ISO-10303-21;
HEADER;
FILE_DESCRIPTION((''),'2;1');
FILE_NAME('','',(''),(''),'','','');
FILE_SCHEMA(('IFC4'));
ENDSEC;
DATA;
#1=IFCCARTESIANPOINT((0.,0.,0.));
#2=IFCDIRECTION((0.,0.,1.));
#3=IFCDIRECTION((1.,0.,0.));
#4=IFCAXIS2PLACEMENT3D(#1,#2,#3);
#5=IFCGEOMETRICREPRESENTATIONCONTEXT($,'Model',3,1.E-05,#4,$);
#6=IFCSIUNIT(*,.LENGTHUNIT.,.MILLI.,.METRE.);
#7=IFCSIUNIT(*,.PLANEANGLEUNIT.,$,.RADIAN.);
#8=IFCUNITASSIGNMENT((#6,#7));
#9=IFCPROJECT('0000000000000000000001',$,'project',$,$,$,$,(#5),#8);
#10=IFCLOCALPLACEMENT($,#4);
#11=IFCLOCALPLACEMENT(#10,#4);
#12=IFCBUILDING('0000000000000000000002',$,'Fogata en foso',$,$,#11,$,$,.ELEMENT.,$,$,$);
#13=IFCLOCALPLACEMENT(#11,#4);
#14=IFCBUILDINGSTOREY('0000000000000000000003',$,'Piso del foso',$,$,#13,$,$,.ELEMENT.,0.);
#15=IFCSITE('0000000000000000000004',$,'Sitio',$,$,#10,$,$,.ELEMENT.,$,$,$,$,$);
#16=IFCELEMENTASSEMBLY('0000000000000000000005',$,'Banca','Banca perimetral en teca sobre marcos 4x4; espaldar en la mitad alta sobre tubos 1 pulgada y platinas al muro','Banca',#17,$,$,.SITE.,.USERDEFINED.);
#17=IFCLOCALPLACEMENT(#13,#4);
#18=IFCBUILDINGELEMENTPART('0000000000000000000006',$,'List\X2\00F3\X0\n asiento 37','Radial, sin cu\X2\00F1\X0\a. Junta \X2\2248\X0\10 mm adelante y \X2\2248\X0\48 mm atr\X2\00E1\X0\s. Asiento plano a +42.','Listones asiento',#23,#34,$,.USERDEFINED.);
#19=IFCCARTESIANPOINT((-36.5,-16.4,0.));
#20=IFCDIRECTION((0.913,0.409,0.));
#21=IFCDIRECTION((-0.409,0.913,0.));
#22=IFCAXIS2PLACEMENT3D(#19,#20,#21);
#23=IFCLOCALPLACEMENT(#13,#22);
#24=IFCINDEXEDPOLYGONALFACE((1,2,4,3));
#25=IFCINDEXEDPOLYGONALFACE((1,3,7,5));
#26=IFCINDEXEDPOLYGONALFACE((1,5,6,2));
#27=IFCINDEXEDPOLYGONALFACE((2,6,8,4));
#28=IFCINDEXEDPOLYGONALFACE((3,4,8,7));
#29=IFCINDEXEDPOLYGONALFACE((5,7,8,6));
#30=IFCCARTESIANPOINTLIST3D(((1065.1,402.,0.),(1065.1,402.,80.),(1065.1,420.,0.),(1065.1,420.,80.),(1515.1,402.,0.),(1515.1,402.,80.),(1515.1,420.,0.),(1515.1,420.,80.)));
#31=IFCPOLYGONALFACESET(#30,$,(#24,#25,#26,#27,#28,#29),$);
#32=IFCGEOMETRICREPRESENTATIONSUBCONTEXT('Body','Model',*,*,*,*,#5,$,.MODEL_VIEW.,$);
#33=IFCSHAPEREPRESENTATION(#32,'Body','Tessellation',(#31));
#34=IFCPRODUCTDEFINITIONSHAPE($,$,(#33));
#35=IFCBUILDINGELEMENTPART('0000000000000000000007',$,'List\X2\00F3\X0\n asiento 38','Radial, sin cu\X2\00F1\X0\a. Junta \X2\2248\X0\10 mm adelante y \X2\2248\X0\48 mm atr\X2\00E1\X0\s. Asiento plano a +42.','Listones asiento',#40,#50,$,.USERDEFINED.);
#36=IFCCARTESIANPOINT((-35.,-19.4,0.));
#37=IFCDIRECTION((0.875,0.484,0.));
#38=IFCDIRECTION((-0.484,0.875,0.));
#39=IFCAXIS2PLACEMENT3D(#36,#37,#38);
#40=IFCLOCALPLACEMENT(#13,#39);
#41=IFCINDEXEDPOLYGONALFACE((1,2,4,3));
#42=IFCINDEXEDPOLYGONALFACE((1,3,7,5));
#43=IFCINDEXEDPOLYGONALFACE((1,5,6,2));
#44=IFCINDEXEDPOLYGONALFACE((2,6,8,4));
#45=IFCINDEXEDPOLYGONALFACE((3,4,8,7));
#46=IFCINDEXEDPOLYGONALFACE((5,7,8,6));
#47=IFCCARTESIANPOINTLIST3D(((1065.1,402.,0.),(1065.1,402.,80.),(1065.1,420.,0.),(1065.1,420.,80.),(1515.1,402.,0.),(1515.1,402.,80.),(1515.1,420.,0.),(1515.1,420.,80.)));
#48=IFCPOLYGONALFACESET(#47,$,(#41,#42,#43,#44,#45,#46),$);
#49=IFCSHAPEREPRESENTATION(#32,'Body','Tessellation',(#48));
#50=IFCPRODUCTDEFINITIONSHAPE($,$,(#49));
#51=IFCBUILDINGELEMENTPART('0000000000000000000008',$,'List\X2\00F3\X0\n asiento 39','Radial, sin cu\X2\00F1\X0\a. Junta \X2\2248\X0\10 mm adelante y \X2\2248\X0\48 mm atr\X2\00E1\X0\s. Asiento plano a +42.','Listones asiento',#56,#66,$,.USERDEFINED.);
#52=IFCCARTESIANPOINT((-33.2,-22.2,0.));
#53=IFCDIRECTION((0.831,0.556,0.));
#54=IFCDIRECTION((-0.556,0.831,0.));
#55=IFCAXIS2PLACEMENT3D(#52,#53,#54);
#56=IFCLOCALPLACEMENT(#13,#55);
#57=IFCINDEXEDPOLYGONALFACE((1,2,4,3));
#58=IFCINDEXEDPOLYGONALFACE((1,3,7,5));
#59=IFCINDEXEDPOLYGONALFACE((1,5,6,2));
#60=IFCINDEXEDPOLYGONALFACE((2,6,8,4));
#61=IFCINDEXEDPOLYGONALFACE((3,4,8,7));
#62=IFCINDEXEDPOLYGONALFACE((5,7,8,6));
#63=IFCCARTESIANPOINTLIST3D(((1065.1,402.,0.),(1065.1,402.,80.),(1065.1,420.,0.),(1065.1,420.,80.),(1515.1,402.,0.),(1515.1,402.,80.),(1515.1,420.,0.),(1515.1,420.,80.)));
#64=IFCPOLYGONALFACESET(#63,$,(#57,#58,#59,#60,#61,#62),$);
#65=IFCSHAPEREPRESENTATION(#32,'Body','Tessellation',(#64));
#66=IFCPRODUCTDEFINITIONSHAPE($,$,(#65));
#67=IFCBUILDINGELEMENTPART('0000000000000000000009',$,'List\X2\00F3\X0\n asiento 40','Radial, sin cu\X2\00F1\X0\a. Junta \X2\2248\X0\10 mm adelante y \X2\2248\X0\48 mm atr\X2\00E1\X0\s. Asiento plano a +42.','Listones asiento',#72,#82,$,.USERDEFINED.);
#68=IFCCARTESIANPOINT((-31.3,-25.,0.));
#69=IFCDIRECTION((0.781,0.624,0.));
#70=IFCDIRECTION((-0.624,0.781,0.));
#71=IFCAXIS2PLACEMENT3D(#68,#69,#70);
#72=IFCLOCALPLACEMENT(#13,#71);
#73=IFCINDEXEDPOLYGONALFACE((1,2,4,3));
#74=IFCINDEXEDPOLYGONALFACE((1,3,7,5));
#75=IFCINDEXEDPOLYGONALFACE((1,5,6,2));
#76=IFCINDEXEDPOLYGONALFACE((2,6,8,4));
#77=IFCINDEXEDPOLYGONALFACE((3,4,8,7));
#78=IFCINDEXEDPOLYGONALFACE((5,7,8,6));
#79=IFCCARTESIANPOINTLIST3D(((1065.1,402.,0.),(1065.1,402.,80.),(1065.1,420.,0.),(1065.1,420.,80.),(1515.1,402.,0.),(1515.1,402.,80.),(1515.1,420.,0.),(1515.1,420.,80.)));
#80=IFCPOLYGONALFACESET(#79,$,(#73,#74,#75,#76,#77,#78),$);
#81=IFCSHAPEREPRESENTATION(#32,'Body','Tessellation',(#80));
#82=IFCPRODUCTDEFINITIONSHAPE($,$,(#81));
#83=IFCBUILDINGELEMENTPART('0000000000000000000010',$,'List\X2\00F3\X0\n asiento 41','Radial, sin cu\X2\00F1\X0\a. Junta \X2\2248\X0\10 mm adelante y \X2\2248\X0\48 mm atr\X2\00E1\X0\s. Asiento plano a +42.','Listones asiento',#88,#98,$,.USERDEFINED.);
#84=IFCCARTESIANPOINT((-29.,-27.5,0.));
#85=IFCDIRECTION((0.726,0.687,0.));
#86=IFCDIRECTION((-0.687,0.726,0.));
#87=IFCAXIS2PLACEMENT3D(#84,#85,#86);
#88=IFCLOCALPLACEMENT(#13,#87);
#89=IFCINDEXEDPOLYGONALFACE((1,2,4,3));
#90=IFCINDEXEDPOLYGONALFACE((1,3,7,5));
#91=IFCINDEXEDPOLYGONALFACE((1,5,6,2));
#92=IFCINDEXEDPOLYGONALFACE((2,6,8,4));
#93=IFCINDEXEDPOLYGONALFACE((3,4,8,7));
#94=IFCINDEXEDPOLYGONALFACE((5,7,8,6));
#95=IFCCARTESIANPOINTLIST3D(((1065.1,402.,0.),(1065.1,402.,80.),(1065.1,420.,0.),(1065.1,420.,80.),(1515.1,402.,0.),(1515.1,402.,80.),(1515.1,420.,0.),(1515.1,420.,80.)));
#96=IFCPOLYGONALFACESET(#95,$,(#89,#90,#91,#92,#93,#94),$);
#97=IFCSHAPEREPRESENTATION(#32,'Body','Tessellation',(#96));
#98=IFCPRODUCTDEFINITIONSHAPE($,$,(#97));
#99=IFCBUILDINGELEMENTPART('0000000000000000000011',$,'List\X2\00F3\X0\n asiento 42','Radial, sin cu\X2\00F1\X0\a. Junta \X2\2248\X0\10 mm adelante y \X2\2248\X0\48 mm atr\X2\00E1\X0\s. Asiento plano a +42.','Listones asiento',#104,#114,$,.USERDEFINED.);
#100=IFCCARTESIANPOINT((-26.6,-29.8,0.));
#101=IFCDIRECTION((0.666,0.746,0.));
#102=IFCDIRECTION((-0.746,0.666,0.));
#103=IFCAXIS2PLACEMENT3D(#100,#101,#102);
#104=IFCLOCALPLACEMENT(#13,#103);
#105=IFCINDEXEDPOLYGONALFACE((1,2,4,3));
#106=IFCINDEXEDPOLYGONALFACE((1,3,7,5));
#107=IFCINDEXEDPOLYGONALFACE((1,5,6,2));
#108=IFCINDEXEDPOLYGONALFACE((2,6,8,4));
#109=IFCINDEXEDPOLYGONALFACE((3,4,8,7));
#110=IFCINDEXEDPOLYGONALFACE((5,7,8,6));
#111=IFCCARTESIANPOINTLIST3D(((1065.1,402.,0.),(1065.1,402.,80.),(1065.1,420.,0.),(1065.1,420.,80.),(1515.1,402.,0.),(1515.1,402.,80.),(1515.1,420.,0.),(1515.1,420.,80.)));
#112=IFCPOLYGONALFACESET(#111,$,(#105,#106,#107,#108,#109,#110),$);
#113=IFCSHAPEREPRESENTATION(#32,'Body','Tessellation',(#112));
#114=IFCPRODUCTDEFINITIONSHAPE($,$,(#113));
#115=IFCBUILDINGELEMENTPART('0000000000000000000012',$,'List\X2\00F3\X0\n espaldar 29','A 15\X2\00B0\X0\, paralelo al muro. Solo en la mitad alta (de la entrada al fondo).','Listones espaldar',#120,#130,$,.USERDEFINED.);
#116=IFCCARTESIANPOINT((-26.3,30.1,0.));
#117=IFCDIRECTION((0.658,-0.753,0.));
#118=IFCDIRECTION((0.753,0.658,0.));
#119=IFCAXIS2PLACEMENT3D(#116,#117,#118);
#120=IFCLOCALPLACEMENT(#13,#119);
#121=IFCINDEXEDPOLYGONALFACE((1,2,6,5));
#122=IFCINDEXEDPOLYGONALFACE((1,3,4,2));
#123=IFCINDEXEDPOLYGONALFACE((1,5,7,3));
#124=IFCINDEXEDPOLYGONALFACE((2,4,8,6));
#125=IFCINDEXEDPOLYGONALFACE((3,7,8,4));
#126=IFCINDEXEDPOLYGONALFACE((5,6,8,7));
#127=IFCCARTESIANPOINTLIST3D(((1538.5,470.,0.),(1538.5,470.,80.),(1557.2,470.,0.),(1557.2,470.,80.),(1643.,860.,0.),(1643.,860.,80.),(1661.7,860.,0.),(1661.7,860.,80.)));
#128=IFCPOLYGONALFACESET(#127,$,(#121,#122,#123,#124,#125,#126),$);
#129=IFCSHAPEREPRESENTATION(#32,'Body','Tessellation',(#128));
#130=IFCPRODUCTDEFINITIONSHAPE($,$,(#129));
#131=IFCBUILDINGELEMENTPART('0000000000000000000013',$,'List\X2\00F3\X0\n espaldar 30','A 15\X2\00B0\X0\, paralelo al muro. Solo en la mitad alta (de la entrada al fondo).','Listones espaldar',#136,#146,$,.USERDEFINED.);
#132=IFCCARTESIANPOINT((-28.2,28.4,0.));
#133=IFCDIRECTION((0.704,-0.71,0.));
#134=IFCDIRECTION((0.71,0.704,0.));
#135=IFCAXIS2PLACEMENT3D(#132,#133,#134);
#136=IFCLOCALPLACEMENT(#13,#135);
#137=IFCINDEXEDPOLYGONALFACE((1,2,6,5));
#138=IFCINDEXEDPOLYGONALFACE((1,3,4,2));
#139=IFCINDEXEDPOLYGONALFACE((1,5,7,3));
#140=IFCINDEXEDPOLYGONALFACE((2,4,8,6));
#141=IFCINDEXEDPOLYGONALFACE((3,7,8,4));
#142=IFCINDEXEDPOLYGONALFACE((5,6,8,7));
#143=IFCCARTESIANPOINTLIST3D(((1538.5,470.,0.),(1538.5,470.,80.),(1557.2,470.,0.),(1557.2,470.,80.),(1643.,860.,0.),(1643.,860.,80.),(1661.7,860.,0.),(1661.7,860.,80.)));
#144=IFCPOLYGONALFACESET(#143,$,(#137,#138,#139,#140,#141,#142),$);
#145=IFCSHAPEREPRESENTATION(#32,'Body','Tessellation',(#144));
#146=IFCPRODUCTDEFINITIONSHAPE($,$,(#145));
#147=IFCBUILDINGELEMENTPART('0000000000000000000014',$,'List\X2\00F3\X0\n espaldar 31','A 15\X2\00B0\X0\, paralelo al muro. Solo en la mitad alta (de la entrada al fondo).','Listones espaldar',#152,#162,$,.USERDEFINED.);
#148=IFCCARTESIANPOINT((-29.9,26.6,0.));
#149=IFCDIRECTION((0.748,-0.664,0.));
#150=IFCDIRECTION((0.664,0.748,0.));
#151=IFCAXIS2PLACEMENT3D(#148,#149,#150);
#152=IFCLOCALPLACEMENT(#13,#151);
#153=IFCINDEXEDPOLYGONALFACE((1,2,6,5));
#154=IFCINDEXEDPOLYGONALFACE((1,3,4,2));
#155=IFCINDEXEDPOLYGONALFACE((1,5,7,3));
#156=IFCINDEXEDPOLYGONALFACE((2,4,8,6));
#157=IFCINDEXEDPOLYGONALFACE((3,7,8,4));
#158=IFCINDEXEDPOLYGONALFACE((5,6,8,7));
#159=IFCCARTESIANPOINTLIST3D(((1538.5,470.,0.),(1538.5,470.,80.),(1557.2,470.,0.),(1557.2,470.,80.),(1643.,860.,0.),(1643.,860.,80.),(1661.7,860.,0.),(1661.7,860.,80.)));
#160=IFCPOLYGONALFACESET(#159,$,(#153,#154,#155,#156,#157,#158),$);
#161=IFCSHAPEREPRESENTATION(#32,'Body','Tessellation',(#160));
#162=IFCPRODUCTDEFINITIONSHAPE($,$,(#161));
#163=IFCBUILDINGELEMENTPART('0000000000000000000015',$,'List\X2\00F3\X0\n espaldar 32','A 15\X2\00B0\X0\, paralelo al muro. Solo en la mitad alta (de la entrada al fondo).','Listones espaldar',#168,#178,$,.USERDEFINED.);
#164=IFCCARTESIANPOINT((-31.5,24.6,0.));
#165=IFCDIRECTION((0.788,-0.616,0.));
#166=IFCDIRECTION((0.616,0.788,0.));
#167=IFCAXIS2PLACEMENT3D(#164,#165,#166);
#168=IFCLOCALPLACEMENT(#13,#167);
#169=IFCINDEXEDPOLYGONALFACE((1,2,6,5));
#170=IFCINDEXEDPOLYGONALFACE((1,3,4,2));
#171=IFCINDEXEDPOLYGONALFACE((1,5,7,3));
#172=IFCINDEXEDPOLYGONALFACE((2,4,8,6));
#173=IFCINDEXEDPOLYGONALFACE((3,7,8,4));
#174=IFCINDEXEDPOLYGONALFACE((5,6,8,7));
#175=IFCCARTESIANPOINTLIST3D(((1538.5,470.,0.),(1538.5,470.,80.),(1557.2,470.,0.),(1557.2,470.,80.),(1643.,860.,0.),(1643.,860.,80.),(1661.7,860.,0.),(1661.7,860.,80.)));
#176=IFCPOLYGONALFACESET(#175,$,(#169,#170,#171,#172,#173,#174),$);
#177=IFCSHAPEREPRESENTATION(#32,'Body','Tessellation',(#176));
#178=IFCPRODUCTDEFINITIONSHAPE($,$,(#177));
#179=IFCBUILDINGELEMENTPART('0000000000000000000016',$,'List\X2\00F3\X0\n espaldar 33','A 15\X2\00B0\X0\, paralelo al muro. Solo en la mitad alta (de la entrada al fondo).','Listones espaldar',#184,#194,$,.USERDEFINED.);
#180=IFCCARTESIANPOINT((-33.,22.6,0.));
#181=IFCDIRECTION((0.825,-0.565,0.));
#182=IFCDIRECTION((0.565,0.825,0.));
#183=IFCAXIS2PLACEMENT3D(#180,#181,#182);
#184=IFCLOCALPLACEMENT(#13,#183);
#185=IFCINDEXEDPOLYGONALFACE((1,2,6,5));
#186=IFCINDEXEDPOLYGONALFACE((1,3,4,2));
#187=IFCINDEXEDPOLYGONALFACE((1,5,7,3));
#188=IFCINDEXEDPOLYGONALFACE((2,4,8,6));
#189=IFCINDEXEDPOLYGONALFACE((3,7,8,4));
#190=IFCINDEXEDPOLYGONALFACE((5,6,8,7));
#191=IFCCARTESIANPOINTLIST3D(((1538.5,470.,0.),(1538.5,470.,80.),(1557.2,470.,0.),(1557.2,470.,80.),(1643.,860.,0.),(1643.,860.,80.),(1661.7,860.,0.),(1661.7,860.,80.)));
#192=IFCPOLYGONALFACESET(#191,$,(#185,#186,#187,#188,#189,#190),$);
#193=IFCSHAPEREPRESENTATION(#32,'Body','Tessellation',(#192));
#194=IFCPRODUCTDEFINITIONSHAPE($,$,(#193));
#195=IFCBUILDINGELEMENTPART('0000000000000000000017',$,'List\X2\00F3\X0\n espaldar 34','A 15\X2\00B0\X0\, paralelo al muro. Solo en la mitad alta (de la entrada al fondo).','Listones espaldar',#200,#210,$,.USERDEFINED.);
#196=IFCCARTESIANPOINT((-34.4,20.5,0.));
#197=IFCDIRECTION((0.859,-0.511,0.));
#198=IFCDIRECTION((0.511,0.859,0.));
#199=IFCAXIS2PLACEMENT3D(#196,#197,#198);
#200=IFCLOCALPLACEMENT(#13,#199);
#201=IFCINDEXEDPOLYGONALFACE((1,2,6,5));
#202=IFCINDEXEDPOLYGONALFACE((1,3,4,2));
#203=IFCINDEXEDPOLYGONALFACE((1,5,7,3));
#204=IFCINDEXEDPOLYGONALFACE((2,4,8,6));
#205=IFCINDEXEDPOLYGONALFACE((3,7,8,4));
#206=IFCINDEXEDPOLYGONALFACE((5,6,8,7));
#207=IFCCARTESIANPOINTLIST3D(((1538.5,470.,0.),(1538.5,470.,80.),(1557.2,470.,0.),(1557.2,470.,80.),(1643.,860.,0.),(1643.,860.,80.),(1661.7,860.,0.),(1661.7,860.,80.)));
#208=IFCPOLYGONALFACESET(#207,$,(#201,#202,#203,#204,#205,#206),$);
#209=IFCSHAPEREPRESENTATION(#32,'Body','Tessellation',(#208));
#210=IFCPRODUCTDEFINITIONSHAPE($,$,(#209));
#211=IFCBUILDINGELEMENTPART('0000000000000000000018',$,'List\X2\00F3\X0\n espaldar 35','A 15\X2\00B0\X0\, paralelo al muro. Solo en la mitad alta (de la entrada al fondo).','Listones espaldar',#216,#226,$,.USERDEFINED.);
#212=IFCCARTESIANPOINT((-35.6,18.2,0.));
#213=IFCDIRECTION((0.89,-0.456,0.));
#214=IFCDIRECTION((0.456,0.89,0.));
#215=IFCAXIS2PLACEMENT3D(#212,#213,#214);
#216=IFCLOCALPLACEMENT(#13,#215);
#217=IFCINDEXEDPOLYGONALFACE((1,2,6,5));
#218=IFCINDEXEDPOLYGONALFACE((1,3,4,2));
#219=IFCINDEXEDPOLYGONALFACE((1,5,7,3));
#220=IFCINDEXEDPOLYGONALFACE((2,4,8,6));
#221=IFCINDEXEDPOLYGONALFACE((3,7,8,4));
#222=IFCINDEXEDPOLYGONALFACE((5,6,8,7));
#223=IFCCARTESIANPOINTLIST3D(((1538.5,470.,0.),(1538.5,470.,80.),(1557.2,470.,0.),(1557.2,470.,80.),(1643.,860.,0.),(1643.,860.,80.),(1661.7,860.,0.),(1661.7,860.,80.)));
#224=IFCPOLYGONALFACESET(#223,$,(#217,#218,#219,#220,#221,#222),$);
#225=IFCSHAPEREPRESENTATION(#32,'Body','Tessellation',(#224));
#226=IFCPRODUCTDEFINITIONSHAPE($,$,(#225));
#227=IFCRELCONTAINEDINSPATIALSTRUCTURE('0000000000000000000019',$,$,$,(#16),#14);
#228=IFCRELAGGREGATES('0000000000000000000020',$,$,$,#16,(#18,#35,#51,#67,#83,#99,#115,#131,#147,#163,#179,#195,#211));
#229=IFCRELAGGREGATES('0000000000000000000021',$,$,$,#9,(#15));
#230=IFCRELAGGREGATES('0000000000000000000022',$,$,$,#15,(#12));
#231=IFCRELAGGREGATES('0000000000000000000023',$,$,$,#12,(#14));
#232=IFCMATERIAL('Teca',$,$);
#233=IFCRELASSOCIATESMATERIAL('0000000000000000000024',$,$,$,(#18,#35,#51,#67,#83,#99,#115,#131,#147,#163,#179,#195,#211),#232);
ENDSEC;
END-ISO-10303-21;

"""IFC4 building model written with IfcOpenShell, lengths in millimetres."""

from ifc_helpers import new_model, si_unit, frame, origin_with_axes, place, context, subcontext, project, spatial, polyline, outline, extrude, material, element, aggregate, save


model = new_model("IFC4")

# Units and contexts
model_context = context("Model", 3, precision=1e-05, world=origin_with_axes())
body_context = subcontext(model_context, "Body", "Model", "MODEL_VIEW")
ifc_project = project(units=[si_unit("LENGTHUNIT", "METRE", prefix="MILLI"), si_unit("PLANEANGLEUNIT", "RADIAN")], contexts=[model_context])

# Site, building, storey
site_placement = place(None, origin_with_axes())
site = spatial("IfcSite", under=ifc_project, at=site_placement, Name="Sitio", CompositionType="ELEMENT")
building_placement = place(site_placement, origin_with_axes())
building = spatial("IfcBuilding", under=site, at=building_placement, Name="Fogata en foso", CompositionType="ELEMENT")
storey_placement = place(building_placement, origin_with_axes())
storey = spatial("IfcBuildingStorey", under=building, at=storey_placement, Name="Piso del foso", CompositionType="ELEMENT", Elevation=0.0)

# Element assembly, building element parts
assembly_1_placement = place(storey_placement, origin_with_axes())
assembly_1 = element("IfcElementAssembly", 1, at=assembly_1_placement, inside=storey, Name="Banca", Description="Banca perimetral en teca sobre marcos 4x4; espaldar en la mitad alta sobre tubos 1 pulgada y platinas al muro", ObjectType="Banca", AssemblyPlace="SITE", PredefinedType="USERDEFINED")
ifc_material_1 = material(Name="Teca")
building_element_part_1_placement = place(storey_placement, frame((-36.5, -16.4, 0.0), z_axis=(0.913, 0.409, 0.0), x_axis=(-0.409, 0.913, 0.0)))
building_element_part_1 = element("IfcBuildingElementPart", 2, at=building_element_part_1_placement, material=ifc_material_1, Name="Listón asiento 37", Description="Radial, sin cuña. Junta ≈10 mm adelante y ≈48 mm atrás. Asiento plano a +42.", ObjectType="Listones asiento", PredefinedType="USERDEFINED", context=body_context, shape_type="SweptSolid", body=[
    extrude(outline(polyline([(1065.1, 402.0), (1515.1, 402.0), (1515.1, 420.0), (1065.1, 420.0), (1065.1, 402.0)])), origin_with_axes(), (0.0, 0.0, 1.0), 80.0),
])
building_element_part_2_placement = place(storey_placement, frame((-35.0, -19.4, 0.0), z_axis=(0.875, 0.484, 0.0), x_axis=(-0.484, 0.875, 0.0)))
building_element_part_2 = element("IfcBuildingElementPart", 3, at=building_element_part_2_placement, material=ifc_material_1, Name="Listón asiento 38", Description="Radial, sin cuña. Junta ≈10 mm adelante y ≈48 mm atrás. Asiento plano a +42.", ObjectType="Listones asiento", PredefinedType="USERDEFINED", context=body_context, shape_type="SweptSolid", body=[
    extrude(outline(polyline([(1065.1, 402.0), (1515.1, 402.0), (1515.1, 420.0), (1065.1, 420.0), (1065.1, 402.0)])), origin_with_axes(), (0.0, 0.0, 1.0), 80.0),
])
building_element_part_3_placement = place(storey_placement, frame((-33.2, -22.2, 0.0), z_axis=(0.831, 0.556, 0.0), x_axis=(-0.556, 0.831, 0.0)))
building_element_part_3 = element("IfcBuildingElementPart", 4, at=building_element_part_3_placement, material=ifc_material_1, Name="Listón asiento 39", Description="Radial, sin cuña. Junta ≈10 mm adelante y ≈48 mm atrás. Asiento plano a +42.", ObjectType="Listones asiento", PredefinedType="USERDEFINED", context=body_context, shape_type="SweptSolid", body=[
    extrude(outline(polyline([(1065.1, 402.0), (1515.1, 402.0), (1515.1, 420.0), (1065.1, 420.0), (1065.1, 402.0)])), origin_with_axes(), (0.0, 0.0, 1.0), 80.0),
])
building_element_part_4_placement = place(storey_placement, frame((-31.3, -25.0, 0.0), z_axis=(0.781, 0.624, 0.0), x_axis=(-0.624, 0.781, 0.0)))
building_element_part_4 = element("IfcBuildingElementPart", 5, at=building_element_part_4_placement, material=ifc_material_1, Name="Listón asiento 40", Description="Radial, sin cuña. Junta ≈10 mm adelante y ≈48 mm atrás. Asiento plano a +42.", ObjectType="Listones asiento", PredefinedType="USERDEFINED", context=body_context, shape_type="SweptSolid", body=[
    extrude(outline(polyline([(1065.1, 402.0), (1515.1, 402.0), (1515.1, 420.0), (1065.1, 420.0), (1065.1, 402.0)])), origin_with_axes(), (0.0, 0.0, 1.0), 80.0),
])
building_element_part_5_placement = place(storey_placement, frame((-29.0, -27.5, 0.0), z_axis=(0.726, 0.687, 0.0), x_axis=(-0.687, 0.726, 0.0)))
building_element_part_5 = element("IfcBuildingElementPart", 6, at=building_element_part_5_placement, material=ifc_material_1, Name="Listón asiento 41", Description="Radial, sin cuña. Junta ≈10 mm adelante y ≈48 mm atrás. Asiento plano a +42.", ObjectType="Listones asiento", PredefinedType="USERDEFINED", context=body_context, shape_type="SweptSolid", body=[
    extrude(outline(polyline([(1065.1, 402.0), (1515.1, 402.0), (1515.1, 420.0), (1065.1, 420.0), (1065.1, 402.0)])), origin_with_axes(), (0.0, 0.0, 1.0), 80.0),
])
building_element_part_6_placement = place(storey_placement, frame((-26.6, -29.8, 0.0), z_axis=(0.666, 0.746, 0.0), x_axis=(-0.746, 0.666, 0.0)))
building_element_part_6 = element("IfcBuildingElementPart", 7, at=building_element_part_6_placement, material=ifc_material_1, Name="Listón asiento 42", Description="Radial, sin cuña. Junta ≈10 mm adelante y ≈48 mm atrás. Asiento plano a +42.", ObjectType="Listones asiento", PredefinedType="USERDEFINED", context=body_context, shape_type="SweptSolid", body=[
    extrude(outline(polyline([(1065.1, 402.0), (1515.1, 402.0), (1515.1, 420.0), (1065.1, 420.0), (1065.1, 402.0)])), origin_with_axes(), (0.0, 0.0, 1.0), 80.0),
])
building_element_part_7_placement = place(storey_placement, frame((-26.3, 30.1, 0.0), z_axis=(0.658, -0.753, 0.0), x_axis=(0.753, 0.658, 0.0)))
building_element_part_7 = element("IfcBuildingElementPart", 8, at=building_element_part_7_placement, material=ifc_material_1, Name="Listón espaldar 29", Description="A 15°, paralelo al muro. Solo en la mitad alta (de la entrada al fondo).", ObjectType="Listones espaldar", PredefinedType="USERDEFINED", context=body_context, shape_type="SweptSolid", body=[
    extrude(outline(polyline([(1538.5, 470.0), (1557.2, 470.0), (1661.7, 860.0), (1643.0, 860.0), (1538.5, 470.0)])), origin_with_axes(), (0.0, 0.0, 1.0), 80.0),
])
building_element_part_8_placement = place(storey_placement, frame((-28.2, 28.4, 0.0), z_axis=(0.704, -0.71, 0.0), x_axis=(0.71, 0.704, 0.0)))
building_element_part_8 = element("IfcBuildingElementPart", 9, at=building_element_part_8_placement, material=ifc_material_1, Name="Listón espaldar 30", Description="A 15°, paralelo al muro. Solo en la mitad alta (de la entrada al fondo).", ObjectType="Listones espaldar", PredefinedType="USERDEFINED", context=body_context, shape_type="SweptSolid", body=[
    extrude(outline(polyline([(1538.5, 470.0), (1557.2, 470.0), (1661.7, 860.0), (1643.0, 860.0), (1538.5, 470.0)])), origin_with_axes(), (0.0, 0.0, 1.0), 80.0),
])
building_element_part_9_placement = place(storey_placement, frame((-29.9, 26.6, 0.0), z_axis=(0.748, -0.664, 0.0), x_axis=(0.664, 0.748, 0.0)))
building_element_part_9 = element("IfcBuildingElementPart", 10, at=building_element_part_9_placement, material=ifc_material_1, Name="Listón espaldar 31", Description="A 15°, paralelo al muro. Solo en la mitad alta (de la entrada al fondo).", ObjectType="Listones espaldar", PredefinedType="USERDEFINED", context=body_context, shape_type="SweptSolid", body=[
    extrude(outline(polyline([(1538.5, 470.0), (1557.2, 470.0), (1661.7, 860.0), (1643.0, 860.0), (1538.5, 470.0)])), origin_with_axes(), (0.0, 0.0, 1.0), 80.0),
])
building_element_part_10_placement = place(storey_placement, frame((-31.5, 24.6, 0.0), z_axis=(0.788, -0.616, 0.0), x_axis=(0.616, 0.788, 0.0)))
building_element_part_10 = element("IfcBuildingElementPart", 11, at=building_element_part_10_placement, material=ifc_material_1, Name="Listón espaldar 32", Description="A 15°, paralelo al muro. Solo en la mitad alta (de la entrada al fondo).", ObjectType="Listones espaldar", PredefinedType="USERDEFINED", context=body_context, shape_type="SweptSolid", body=[
    extrude(outline(polyline([(1538.5, 470.0), (1557.2, 470.0), (1661.7, 860.0), (1643.0, 860.0), (1538.5, 470.0)])), origin_with_axes(), (0.0, 0.0, 1.0), 80.0),
])
building_element_part_11_placement = place(storey_placement, frame((-33.0, 22.6, 0.0), z_axis=(0.825, -0.565, 0.0), x_axis=(0.565, 0.825, 0.0)))
building_element_part_11 = element("IfcBuildingElementPart", 12, at=building_element_part_11_placement, material=ifc_material_1, Name="Listón espaldar 33", Description="A 15°, paralelo al muro. Solo en la mitad alta (de la entrada al fondo).", ObjectType="Listones espaldar", PredefinedType="USERDEFINED", context=body_context, shape_type="SweptSolid", body=[
    extrude(outline(polyline([(1538.5, 470.0), (1557.2, 470.0), (1661.7, 860.0), (1643.0, 860.0), (1538.5, 470.0)])), origin_with_axes(), (0.0, 0.0, 1.0), 80.0),
])
building_element_part_12_placement = place(storey_placement, frame((-34.4, 20.5, 0.0), z_axis=(0.859, -0.511, 0.0), x_axis=(0.511, 0.859, 0.0)))
building_element_part_12 = element("IfcBuildingElementPart", 13, at=building_element_part_12_placement, material=ifc_material_1, Name="Listón espaldar 34", Description="A 15°, paralelo al muro. Solo en la mitad alta (de la entrada al fondo).", ObjectType="Listones espaldar", PredefinedType="USERDEFINED", context=body_context, shape_type="SweptSolid", body=[
    extrude(outline(polyline([(1538.5, 470.0), (1557.2, 470.0), (1661.7, 860.0), (1643.0, 860.0), (1538.5, 470.0)])), origin_with_axes(), (0.0, 0.0, 1.0), 80.0),
])
building_element_part_13_placement = place(storey_placement, frame((-35.6, 18.2, 0.0), z_axis=(0.89, -0.456, 0.0), x_axis=(0.456, 0.89, 0.0)))
building_element_part_13 = element("IfcBuildingElementPart", 14, at=building_element_part_13_placement, material=ifc_material_1, Name="Listón espaldar 35", Description="A 15°, paralelo al muro. Solo en la mitad alta (de la entrada al fondo).", ObjectType="Listones espaldar", PredefinedType="USERDEFINED", context=body_context, shape_type="SweptSolid", body=[
    extrude(outline(polyline([(1538.5, 470.0), (1557.2, 470.0), (1661.7, 860.0), (1643.0, 860.0), (1538.5, 470.0)])), origin_with_axes(), (0.0, 0.0, 1.0), 80.0),
])
aggregate(assembly_1, [building_element_part_1, building_element_part_2, building_element_part_3, building_element_part_4, building_element_part_5, building_element_part_6, building_element_part_7, building_element_part_8, building_element_part_9, building_element_part_10, building_element_part_11, building_element_part_12, building_element_part_13])

save(model, "model.ifc")
